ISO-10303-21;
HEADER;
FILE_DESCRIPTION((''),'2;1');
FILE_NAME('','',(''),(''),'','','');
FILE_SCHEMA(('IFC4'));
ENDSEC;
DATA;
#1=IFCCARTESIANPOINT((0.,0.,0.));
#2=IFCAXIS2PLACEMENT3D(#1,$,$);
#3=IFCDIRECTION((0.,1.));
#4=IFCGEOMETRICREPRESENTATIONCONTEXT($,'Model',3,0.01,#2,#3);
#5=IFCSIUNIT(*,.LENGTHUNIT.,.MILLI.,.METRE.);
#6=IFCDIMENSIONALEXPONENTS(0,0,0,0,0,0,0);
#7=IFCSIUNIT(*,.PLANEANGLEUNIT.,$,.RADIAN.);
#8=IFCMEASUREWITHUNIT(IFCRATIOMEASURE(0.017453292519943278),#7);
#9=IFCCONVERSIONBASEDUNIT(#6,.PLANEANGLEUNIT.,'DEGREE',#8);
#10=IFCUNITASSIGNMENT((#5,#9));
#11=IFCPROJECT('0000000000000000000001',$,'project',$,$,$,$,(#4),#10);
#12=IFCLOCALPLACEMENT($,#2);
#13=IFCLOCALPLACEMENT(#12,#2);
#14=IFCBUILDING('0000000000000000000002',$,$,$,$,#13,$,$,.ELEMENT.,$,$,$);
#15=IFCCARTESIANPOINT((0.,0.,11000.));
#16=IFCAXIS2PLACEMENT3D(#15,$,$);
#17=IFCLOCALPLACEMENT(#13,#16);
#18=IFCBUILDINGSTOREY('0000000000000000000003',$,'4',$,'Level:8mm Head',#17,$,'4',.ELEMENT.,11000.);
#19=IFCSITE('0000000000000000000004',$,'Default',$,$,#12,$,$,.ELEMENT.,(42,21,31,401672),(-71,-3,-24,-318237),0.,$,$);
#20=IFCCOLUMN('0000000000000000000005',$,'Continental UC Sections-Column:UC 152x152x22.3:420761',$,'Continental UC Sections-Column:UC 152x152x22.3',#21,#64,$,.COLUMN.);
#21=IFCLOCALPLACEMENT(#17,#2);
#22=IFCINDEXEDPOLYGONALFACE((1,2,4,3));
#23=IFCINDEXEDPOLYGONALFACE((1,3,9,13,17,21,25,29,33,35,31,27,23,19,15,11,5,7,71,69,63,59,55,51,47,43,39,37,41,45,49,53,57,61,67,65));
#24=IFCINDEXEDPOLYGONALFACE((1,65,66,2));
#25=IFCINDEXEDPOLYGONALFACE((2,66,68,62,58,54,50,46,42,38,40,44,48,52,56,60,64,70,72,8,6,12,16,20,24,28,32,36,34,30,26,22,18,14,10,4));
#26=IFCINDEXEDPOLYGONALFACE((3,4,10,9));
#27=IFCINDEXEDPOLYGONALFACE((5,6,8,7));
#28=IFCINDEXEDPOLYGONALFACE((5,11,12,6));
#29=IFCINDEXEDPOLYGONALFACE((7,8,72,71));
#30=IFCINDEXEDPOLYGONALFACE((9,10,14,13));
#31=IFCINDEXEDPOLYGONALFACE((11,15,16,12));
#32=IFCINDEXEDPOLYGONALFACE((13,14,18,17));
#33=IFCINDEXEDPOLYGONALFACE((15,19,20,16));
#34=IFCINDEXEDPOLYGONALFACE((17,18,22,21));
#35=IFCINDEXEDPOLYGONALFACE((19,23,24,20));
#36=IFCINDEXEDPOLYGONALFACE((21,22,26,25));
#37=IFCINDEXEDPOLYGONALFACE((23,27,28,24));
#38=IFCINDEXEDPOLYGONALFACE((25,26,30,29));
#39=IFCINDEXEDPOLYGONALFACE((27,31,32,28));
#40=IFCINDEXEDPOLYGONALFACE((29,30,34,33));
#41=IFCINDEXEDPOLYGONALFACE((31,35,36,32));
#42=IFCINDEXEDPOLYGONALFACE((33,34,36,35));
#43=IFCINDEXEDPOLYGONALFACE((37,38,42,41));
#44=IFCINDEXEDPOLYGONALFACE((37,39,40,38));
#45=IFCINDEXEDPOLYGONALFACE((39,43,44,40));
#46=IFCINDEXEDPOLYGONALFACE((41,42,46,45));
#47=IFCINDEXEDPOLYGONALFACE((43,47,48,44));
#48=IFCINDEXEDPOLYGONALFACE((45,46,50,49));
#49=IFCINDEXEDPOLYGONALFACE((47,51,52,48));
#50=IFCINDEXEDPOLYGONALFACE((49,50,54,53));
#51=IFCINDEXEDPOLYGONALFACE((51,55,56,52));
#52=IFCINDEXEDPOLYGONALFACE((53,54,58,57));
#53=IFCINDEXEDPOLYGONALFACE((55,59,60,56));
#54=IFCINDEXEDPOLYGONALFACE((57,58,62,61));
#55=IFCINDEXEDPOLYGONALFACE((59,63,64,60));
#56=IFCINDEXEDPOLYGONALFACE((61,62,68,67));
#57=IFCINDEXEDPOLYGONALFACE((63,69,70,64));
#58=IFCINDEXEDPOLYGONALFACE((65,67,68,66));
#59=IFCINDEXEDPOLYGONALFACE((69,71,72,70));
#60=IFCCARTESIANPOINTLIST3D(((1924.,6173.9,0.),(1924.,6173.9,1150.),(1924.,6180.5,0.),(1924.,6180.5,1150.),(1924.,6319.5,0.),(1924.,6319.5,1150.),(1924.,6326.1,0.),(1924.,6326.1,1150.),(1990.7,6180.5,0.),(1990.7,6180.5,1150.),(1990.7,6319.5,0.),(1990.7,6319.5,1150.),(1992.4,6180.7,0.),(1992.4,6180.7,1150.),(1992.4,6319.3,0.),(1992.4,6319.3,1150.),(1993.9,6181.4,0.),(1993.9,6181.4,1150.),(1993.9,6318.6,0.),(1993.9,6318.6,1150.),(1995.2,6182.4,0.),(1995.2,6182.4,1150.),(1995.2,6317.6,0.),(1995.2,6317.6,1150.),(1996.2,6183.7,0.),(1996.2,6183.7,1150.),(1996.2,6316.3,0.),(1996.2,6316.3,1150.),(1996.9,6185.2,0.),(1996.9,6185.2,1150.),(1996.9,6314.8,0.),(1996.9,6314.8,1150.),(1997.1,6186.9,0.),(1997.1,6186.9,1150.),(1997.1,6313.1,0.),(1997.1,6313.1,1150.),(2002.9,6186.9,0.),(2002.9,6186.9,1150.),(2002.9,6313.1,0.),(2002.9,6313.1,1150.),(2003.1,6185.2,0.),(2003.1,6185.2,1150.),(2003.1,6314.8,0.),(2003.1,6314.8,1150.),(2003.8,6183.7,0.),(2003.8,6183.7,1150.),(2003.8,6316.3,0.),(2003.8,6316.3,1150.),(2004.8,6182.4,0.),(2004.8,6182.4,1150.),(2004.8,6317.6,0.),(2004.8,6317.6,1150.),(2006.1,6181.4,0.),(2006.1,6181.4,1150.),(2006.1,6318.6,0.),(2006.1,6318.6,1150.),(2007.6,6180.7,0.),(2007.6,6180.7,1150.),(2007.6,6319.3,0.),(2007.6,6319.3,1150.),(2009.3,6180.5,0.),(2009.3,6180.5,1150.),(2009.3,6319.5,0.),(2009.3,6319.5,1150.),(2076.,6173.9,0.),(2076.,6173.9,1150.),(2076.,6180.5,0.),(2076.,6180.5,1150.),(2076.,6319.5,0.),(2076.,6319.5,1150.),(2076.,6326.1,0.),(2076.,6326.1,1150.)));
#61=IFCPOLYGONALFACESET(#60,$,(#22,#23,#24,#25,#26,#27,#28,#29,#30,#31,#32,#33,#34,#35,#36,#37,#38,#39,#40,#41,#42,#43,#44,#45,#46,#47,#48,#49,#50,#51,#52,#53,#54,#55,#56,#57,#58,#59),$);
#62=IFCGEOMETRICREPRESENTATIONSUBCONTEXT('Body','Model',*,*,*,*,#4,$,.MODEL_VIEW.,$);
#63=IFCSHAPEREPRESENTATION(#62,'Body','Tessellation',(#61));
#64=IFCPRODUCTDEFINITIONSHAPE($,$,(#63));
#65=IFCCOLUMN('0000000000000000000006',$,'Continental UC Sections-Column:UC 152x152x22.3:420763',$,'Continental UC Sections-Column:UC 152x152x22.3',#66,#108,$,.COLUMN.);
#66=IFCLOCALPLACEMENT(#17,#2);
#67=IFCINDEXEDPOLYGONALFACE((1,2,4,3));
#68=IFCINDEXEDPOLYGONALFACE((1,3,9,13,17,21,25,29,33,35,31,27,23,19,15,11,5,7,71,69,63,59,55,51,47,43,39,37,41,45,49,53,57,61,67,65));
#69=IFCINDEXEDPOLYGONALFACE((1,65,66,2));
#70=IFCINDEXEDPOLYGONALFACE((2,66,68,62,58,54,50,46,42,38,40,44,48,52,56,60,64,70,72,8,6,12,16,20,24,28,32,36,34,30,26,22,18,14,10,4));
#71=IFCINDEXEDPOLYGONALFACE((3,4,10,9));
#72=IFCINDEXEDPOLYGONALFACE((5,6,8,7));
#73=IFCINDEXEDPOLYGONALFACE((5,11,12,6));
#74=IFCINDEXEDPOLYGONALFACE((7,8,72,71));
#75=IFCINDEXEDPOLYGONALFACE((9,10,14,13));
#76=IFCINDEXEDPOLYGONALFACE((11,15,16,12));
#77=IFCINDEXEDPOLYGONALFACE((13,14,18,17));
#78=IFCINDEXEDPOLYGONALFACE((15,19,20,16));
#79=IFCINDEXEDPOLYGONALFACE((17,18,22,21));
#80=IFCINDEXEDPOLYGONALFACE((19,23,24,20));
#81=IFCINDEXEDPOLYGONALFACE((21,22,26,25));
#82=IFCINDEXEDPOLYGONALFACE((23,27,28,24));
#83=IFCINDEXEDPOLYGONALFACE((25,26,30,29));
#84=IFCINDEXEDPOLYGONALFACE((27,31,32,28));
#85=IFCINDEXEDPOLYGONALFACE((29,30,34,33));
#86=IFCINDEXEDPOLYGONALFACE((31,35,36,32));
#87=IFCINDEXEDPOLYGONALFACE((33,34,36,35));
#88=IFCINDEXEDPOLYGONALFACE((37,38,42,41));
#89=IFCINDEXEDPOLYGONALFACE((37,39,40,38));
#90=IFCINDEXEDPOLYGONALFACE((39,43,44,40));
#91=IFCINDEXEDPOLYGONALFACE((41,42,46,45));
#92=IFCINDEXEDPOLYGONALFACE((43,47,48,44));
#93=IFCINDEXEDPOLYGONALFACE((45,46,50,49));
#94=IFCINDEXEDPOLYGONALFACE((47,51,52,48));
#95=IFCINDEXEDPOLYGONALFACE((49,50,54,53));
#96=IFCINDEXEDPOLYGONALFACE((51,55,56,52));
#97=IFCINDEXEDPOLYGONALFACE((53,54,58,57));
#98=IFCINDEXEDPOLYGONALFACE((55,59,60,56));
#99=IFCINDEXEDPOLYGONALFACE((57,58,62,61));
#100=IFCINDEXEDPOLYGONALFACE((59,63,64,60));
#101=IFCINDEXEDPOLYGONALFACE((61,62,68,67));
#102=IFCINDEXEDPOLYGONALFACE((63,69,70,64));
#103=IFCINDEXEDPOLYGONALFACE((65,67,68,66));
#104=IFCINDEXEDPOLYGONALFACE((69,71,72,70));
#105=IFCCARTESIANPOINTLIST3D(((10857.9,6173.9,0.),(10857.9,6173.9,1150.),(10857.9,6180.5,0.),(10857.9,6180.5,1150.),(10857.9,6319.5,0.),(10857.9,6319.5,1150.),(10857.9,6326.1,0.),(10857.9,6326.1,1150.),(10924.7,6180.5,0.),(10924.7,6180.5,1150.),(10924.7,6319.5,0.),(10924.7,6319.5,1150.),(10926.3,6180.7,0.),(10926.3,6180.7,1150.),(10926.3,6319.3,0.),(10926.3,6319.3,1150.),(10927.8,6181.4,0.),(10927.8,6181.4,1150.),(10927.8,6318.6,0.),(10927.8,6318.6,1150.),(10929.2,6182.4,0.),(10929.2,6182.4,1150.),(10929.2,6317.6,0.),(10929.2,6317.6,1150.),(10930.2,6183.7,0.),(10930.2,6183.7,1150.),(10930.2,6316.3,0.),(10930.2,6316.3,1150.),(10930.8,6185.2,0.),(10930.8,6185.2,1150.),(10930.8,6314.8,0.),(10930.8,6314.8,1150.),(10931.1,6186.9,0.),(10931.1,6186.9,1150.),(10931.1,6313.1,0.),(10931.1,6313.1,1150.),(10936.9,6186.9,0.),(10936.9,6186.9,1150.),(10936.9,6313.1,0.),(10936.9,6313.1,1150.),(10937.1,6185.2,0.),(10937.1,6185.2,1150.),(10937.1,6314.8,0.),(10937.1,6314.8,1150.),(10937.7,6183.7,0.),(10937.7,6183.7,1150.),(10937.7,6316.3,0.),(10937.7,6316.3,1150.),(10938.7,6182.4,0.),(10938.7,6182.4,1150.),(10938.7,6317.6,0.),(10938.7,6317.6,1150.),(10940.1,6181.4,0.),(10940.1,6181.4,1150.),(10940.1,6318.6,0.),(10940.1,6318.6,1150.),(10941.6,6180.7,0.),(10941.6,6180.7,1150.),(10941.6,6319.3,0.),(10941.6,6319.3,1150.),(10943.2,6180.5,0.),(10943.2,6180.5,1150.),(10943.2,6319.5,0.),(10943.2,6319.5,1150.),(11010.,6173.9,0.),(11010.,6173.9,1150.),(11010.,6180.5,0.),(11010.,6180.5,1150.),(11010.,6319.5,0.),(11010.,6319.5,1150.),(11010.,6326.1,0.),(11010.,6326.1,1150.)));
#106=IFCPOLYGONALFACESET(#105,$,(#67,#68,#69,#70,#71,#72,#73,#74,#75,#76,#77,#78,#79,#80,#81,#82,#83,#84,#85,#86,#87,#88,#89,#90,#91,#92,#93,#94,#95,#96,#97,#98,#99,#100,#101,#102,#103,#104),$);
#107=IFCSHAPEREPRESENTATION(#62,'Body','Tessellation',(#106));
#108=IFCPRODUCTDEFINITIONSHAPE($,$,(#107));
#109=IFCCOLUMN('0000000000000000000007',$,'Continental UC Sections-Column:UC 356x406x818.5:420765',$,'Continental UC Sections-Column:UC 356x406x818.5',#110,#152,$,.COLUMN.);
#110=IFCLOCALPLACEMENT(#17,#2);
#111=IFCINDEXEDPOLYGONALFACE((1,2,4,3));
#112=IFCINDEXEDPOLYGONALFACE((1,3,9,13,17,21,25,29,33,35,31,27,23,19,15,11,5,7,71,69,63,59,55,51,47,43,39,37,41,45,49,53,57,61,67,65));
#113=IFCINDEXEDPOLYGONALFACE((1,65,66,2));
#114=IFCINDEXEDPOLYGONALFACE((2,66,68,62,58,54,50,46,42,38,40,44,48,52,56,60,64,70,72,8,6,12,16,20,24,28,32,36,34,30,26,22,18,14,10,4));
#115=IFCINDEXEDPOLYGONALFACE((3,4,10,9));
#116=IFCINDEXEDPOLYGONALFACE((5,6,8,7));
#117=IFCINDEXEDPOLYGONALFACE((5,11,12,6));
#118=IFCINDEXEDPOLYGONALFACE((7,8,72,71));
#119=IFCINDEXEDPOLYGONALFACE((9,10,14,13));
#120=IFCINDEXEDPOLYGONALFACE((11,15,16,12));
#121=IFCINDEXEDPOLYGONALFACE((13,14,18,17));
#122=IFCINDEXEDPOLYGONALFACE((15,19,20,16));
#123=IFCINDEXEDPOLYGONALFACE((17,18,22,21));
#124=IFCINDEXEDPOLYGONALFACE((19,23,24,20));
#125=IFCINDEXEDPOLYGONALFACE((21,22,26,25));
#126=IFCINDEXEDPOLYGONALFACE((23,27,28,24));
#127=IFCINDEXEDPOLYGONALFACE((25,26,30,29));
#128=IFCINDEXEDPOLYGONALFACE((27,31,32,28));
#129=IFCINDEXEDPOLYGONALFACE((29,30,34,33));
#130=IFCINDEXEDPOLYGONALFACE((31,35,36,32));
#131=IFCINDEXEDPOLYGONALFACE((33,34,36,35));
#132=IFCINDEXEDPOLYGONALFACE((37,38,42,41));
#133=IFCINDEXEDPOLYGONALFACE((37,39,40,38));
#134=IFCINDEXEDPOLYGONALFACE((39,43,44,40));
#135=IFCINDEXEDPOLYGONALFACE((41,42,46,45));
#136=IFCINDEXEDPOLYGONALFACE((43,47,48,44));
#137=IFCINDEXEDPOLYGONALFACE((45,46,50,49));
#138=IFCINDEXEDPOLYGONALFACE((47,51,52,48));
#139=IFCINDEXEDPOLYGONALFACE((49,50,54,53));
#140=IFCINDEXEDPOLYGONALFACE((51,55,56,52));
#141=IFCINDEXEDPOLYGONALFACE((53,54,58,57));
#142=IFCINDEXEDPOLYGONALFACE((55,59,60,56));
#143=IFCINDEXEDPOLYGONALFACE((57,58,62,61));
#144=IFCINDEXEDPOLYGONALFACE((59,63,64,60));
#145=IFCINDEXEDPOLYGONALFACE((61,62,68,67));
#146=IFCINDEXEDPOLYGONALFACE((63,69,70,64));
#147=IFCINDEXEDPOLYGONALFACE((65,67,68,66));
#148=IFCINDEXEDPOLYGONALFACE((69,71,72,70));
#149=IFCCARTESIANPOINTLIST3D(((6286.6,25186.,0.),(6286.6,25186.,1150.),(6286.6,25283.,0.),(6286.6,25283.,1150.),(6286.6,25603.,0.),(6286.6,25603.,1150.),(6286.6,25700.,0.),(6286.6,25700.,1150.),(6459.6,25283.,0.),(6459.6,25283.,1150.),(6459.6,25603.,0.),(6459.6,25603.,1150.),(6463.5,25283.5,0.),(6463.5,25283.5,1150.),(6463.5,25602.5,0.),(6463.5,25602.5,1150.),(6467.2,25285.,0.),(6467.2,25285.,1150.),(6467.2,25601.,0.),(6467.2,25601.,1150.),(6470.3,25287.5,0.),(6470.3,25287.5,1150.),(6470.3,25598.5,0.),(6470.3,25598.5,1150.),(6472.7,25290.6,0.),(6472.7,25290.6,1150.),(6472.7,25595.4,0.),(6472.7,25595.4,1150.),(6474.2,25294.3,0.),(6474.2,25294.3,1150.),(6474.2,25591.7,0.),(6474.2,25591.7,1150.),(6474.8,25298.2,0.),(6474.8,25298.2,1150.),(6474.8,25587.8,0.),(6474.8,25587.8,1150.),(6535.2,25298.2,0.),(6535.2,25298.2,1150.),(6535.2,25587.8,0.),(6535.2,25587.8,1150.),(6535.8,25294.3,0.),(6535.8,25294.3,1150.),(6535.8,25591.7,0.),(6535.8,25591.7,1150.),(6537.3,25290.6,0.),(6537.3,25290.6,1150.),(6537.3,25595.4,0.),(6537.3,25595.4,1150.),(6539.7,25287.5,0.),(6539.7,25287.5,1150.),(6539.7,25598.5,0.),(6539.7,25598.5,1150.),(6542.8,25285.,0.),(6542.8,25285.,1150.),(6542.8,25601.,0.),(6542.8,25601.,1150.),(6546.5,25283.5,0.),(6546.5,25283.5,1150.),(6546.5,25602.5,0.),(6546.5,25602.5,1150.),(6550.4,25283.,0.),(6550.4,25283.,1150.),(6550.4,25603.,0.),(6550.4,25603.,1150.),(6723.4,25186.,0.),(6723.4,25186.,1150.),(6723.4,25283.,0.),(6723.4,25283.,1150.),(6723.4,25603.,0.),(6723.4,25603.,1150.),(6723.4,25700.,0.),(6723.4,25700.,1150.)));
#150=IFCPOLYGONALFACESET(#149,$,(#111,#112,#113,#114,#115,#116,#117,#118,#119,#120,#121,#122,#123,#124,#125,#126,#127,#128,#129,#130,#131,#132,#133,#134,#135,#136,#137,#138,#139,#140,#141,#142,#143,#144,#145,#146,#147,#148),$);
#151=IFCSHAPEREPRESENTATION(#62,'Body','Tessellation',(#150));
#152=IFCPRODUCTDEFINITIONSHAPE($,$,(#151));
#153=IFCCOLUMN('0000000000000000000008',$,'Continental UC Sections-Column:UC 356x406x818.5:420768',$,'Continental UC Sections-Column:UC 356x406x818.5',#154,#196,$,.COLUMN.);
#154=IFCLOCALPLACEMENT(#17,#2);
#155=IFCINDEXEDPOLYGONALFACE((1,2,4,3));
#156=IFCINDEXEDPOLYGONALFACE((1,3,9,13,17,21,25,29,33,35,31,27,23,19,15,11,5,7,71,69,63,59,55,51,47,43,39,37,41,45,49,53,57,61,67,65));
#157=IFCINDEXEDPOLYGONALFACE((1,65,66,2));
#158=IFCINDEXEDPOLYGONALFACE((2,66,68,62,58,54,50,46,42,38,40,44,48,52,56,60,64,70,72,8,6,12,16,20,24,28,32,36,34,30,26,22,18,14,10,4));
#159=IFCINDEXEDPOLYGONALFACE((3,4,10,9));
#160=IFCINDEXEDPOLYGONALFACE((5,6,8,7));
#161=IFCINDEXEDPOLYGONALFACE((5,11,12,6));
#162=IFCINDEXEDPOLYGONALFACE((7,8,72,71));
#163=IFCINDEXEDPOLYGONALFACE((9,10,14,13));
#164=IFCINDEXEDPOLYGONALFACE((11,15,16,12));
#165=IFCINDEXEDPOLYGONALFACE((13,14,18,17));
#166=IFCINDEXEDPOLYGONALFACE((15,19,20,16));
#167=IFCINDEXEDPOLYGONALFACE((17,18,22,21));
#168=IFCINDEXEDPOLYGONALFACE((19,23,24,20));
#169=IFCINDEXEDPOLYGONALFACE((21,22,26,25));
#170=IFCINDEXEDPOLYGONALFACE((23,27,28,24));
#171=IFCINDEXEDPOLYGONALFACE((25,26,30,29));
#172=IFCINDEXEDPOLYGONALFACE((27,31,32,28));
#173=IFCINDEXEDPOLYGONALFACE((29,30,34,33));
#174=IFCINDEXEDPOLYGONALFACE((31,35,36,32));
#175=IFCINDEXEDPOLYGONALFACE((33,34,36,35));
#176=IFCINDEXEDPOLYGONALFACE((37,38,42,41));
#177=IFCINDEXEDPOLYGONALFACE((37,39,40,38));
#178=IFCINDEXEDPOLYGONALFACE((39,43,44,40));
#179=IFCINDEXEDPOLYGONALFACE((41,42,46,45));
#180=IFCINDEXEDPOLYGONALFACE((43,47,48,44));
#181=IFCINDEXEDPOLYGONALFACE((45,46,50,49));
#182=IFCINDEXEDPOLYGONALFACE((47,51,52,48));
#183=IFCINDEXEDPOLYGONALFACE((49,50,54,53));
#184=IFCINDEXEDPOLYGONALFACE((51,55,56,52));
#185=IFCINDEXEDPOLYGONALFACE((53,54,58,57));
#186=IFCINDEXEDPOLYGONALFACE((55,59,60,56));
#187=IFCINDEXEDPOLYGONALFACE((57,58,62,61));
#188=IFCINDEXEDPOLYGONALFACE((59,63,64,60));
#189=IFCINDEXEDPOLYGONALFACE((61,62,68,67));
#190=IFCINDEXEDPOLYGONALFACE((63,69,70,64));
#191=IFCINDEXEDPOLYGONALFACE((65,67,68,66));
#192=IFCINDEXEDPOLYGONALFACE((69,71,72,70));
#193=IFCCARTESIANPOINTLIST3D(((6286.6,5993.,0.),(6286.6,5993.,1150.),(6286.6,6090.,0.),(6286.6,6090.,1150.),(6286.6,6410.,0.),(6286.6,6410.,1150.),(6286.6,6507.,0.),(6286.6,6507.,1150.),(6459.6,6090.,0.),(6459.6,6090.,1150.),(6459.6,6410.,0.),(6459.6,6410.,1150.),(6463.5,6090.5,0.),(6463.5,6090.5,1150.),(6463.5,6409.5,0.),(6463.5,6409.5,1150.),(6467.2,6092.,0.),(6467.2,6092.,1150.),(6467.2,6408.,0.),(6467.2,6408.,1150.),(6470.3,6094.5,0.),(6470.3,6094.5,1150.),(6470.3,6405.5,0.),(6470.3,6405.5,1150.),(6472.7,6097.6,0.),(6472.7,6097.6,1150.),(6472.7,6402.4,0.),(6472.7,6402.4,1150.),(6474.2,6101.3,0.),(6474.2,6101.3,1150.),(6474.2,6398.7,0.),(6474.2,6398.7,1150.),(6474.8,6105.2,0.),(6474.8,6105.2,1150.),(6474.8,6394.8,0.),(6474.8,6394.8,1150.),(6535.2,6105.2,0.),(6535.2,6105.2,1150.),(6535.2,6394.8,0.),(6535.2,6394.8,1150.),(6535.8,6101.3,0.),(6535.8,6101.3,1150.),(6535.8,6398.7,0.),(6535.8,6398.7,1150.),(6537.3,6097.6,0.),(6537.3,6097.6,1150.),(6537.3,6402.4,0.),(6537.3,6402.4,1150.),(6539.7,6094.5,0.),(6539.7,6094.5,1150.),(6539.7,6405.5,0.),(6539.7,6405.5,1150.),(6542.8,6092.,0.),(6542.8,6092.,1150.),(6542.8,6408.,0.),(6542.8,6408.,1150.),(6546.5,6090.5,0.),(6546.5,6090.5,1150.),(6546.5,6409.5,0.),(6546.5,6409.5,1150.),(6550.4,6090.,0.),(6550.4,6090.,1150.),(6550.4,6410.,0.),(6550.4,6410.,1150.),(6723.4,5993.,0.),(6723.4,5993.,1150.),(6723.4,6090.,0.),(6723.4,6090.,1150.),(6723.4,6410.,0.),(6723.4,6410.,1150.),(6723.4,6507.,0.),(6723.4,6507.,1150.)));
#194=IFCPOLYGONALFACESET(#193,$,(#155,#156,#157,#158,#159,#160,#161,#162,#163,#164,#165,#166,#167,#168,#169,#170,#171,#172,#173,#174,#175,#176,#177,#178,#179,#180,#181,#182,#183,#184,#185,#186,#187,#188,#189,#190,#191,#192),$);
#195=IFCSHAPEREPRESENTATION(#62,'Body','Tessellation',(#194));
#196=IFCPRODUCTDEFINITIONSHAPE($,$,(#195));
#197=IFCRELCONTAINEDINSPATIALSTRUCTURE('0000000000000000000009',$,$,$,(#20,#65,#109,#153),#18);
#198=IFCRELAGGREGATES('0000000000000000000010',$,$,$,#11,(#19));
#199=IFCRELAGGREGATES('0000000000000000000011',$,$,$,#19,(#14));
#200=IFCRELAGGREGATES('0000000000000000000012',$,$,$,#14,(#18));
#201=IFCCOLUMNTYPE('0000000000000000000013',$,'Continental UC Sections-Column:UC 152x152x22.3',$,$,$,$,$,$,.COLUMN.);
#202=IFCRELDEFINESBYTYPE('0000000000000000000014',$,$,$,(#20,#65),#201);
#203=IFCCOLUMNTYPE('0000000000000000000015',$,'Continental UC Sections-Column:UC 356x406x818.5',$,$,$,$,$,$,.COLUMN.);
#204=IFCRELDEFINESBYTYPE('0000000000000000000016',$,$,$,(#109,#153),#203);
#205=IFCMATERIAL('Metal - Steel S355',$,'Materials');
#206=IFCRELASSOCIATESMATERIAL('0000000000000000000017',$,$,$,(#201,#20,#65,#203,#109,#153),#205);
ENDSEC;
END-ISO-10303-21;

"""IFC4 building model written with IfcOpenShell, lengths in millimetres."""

from ifc_helpers import new_model, entity, si_unit, converted_unit, direction, frame, origin, place, context, subcontext, project, spatial, line, arc, indexed_curve, outline, extrude, source, transform, mapped, material, type_object, type_shapes, element, save


model = new_model("IFC4")

# Units and contexts
model_context = context("Model", 3, precision=0.01, world=origin(), true_north=direction((0.0, 1.0)))
body_context = subcontext(model_context, "Body", "Model", "MODEL_VIEW")
ifc_project = project(units=[si_unit("LENGTHUNIT", "METRE", prefix="MILLI"), converted_unit("PLANEANGLEUNIT", "DEGREE", entity("IfcRatioMeasure", 0.017453292519943278), si_unit("PLANEANGLEUNIT", "RADIAN"), dimensions=[0, 0, 0, 0, 0, 0, 0])], contexts=[model_context])

# Site, building, storey
site_placement = place(None, origin())
site = spatial("IfcSite", under=ifc_project, at=site_placement, Name="Default", CompositionType="ELEMENT", RefLatitude=(42, 21, 31, 401672), RefLongitude=(-71, -3, -24, -318237), RefElevation=0.0)
building_placement = place(site_placement, origin())
building = spatial("IfcBuilding", under=site, at=building_placement, CompositionType="ELEMENT")
storey_placement = place(building_placement, frame((0.0, 0.0, 11000.0)))
storey = spatial("IfcBuildingStorey", under=building, at=storey_placement, Name="4", ObjectType="Level:8mm Head", LongName="4", CompositionType="ELEMENT", Elevation=11000.0)

# Columns
ifc_material_1 = material(Name="Metal - Steel S355", Category="Materials")
column_type_1 = type_object("IfcColumnType", Name="Continental UC Sections-Column:UC 152x152x22.3", PredefinedType="COLUMN", material=ifc_material_1)
shared_shape_1 = source(origin(), body_context, "Body", "SweptSolid", [
    extrude(outline(indexed_curve([(69.5, -76.0), (76.1, -76.0), (76.1, 76.0), (69.5, 76.0), (69.5, 9.3), (67.6, 4.8), (63.1, 2.9), (-63.1, 2.9), (-67.6, 4.8), (-69.5, 9.3), (-69.5, 76.0), (-76.1, 76.0), (-76.1, -76.0), (-69.5, -76.0), (-69.5, -9.3), (-67.6, -4.8), (-63.1, -2.9), (63.1, -2.9), (67.6, -4.8), (69.5, -9.3)], segments=[line(1, 2, 3, 4, 5), arc(5, 6, 7), line(7, 8), arc(8, 9, 10), line(10, 11, 12, 13, 14, 15), arc(15, 16, 17), line(17, 18), arc(18, 19, 20), line(20, 1)], self_intersect=False)), frame((0.0, 0.0, 11000.0), z_axis=(0.0, 0.0, 1.0), x_axis=(0.0, -1.0, 0.0)), (0.0, 0.0, 1.0), 1150.0),
])
type_shapes(column_type_1, [shared_shape_1])
for number, where, name in (
    (1, (2000.0, 6250.0, -11000.0), "Continental UC Sections-Column:UC 152x152x22.3:420761"),
    (2, (10934.0, 6250.0, -11000.0), "Continental UC Sections-Column:UC 152x152x22.3:420763"),
):
    element("IfcColumn", number, at=place(storey_placement, frame(where)), inside=storey, type_object=column_type_1, material=ifc_material_1, Name=name, ObjectType="Continental UC Sections-Column:UC 152x152x22.3", PredefinedType="COLUMN", context=body_context, shape_type="MappedRepresentation", body=[
        mapped(shared_shape_1, transform((0.0, 0.0, 0.0), scale=1.0)),
    ])
column_type_2 = type_object("IfcColumnType", Name="Continental UC Sections-Column:UC 356x406x818.5", PredefinedType="COLUMN", material=ifc_material_1)
shared_shape_2 = source(origin(), body_context, "Body", "SweptSolid", [
    extrude(outline(indexed_curve([(160.0, -218.4), (257.0, -218.4), (257.0, 218.4), (160.0, 218.4), (160.0, 45.5), (155.5, 34.7), (144.8, 30.3), (-144.8, 30.3), (-155.5, 34.7), (-160.0, 45.5), (-160.0, 218.4), (-257.0, 218.4), (-257.0, -218.4), (-160.0, -218.4), (-160.0, -45.5), (-155.5, -34.7), (-144.8, -30.2), (144.8, -30.2), (155.5, -34.7), (160.0, -45.4)], segments=[line(1, 2, 3, 4, 5), arc(5, 6, 7), line(7, 8), arc(8, 9, 10), line(10, 11, 12, 13, 14, 15), arc(15, 16, 17), line(17, 18), arc(18, 19, 20), line(20, 1)], self_intersect=False)), frame((0.0, 0.0, 11000.0), z_axis=(0.0, 0.0, 1.0), x_axis=(0.0, -1.0, 0.0)), (0.0, 0.0, 1.0), 1150.0),
])
type_shapes(column_type_2, [shared_shape_2])
for number, where, name in (
    (3, (6505.0, 25443.0, -11000.0), "Continental UC Sections-Column:UC 356x406x818.5:420765"),
    (4, (6505.0, 6250.0, -11000.0), "Continental UC Sections-Column:UC 356x406x818.5:420768"),
):
    element("IfcColumn", number, at=place(storey_placement, frame(where)), inside=storey, type_object=column_type_2, material=ifc_material_1, Name=name, ObjectType="Continental UC Sections-Column:UC 356x406x818.5", PredefinedType="COLUMN", context=body_context, shape_type="MappedRepresentation", body=[
        mapped(shared_shape_2, transform((0.0, 0.0, 0.0), scale=1.0)),
    ])

save(model, "model.ifc")
